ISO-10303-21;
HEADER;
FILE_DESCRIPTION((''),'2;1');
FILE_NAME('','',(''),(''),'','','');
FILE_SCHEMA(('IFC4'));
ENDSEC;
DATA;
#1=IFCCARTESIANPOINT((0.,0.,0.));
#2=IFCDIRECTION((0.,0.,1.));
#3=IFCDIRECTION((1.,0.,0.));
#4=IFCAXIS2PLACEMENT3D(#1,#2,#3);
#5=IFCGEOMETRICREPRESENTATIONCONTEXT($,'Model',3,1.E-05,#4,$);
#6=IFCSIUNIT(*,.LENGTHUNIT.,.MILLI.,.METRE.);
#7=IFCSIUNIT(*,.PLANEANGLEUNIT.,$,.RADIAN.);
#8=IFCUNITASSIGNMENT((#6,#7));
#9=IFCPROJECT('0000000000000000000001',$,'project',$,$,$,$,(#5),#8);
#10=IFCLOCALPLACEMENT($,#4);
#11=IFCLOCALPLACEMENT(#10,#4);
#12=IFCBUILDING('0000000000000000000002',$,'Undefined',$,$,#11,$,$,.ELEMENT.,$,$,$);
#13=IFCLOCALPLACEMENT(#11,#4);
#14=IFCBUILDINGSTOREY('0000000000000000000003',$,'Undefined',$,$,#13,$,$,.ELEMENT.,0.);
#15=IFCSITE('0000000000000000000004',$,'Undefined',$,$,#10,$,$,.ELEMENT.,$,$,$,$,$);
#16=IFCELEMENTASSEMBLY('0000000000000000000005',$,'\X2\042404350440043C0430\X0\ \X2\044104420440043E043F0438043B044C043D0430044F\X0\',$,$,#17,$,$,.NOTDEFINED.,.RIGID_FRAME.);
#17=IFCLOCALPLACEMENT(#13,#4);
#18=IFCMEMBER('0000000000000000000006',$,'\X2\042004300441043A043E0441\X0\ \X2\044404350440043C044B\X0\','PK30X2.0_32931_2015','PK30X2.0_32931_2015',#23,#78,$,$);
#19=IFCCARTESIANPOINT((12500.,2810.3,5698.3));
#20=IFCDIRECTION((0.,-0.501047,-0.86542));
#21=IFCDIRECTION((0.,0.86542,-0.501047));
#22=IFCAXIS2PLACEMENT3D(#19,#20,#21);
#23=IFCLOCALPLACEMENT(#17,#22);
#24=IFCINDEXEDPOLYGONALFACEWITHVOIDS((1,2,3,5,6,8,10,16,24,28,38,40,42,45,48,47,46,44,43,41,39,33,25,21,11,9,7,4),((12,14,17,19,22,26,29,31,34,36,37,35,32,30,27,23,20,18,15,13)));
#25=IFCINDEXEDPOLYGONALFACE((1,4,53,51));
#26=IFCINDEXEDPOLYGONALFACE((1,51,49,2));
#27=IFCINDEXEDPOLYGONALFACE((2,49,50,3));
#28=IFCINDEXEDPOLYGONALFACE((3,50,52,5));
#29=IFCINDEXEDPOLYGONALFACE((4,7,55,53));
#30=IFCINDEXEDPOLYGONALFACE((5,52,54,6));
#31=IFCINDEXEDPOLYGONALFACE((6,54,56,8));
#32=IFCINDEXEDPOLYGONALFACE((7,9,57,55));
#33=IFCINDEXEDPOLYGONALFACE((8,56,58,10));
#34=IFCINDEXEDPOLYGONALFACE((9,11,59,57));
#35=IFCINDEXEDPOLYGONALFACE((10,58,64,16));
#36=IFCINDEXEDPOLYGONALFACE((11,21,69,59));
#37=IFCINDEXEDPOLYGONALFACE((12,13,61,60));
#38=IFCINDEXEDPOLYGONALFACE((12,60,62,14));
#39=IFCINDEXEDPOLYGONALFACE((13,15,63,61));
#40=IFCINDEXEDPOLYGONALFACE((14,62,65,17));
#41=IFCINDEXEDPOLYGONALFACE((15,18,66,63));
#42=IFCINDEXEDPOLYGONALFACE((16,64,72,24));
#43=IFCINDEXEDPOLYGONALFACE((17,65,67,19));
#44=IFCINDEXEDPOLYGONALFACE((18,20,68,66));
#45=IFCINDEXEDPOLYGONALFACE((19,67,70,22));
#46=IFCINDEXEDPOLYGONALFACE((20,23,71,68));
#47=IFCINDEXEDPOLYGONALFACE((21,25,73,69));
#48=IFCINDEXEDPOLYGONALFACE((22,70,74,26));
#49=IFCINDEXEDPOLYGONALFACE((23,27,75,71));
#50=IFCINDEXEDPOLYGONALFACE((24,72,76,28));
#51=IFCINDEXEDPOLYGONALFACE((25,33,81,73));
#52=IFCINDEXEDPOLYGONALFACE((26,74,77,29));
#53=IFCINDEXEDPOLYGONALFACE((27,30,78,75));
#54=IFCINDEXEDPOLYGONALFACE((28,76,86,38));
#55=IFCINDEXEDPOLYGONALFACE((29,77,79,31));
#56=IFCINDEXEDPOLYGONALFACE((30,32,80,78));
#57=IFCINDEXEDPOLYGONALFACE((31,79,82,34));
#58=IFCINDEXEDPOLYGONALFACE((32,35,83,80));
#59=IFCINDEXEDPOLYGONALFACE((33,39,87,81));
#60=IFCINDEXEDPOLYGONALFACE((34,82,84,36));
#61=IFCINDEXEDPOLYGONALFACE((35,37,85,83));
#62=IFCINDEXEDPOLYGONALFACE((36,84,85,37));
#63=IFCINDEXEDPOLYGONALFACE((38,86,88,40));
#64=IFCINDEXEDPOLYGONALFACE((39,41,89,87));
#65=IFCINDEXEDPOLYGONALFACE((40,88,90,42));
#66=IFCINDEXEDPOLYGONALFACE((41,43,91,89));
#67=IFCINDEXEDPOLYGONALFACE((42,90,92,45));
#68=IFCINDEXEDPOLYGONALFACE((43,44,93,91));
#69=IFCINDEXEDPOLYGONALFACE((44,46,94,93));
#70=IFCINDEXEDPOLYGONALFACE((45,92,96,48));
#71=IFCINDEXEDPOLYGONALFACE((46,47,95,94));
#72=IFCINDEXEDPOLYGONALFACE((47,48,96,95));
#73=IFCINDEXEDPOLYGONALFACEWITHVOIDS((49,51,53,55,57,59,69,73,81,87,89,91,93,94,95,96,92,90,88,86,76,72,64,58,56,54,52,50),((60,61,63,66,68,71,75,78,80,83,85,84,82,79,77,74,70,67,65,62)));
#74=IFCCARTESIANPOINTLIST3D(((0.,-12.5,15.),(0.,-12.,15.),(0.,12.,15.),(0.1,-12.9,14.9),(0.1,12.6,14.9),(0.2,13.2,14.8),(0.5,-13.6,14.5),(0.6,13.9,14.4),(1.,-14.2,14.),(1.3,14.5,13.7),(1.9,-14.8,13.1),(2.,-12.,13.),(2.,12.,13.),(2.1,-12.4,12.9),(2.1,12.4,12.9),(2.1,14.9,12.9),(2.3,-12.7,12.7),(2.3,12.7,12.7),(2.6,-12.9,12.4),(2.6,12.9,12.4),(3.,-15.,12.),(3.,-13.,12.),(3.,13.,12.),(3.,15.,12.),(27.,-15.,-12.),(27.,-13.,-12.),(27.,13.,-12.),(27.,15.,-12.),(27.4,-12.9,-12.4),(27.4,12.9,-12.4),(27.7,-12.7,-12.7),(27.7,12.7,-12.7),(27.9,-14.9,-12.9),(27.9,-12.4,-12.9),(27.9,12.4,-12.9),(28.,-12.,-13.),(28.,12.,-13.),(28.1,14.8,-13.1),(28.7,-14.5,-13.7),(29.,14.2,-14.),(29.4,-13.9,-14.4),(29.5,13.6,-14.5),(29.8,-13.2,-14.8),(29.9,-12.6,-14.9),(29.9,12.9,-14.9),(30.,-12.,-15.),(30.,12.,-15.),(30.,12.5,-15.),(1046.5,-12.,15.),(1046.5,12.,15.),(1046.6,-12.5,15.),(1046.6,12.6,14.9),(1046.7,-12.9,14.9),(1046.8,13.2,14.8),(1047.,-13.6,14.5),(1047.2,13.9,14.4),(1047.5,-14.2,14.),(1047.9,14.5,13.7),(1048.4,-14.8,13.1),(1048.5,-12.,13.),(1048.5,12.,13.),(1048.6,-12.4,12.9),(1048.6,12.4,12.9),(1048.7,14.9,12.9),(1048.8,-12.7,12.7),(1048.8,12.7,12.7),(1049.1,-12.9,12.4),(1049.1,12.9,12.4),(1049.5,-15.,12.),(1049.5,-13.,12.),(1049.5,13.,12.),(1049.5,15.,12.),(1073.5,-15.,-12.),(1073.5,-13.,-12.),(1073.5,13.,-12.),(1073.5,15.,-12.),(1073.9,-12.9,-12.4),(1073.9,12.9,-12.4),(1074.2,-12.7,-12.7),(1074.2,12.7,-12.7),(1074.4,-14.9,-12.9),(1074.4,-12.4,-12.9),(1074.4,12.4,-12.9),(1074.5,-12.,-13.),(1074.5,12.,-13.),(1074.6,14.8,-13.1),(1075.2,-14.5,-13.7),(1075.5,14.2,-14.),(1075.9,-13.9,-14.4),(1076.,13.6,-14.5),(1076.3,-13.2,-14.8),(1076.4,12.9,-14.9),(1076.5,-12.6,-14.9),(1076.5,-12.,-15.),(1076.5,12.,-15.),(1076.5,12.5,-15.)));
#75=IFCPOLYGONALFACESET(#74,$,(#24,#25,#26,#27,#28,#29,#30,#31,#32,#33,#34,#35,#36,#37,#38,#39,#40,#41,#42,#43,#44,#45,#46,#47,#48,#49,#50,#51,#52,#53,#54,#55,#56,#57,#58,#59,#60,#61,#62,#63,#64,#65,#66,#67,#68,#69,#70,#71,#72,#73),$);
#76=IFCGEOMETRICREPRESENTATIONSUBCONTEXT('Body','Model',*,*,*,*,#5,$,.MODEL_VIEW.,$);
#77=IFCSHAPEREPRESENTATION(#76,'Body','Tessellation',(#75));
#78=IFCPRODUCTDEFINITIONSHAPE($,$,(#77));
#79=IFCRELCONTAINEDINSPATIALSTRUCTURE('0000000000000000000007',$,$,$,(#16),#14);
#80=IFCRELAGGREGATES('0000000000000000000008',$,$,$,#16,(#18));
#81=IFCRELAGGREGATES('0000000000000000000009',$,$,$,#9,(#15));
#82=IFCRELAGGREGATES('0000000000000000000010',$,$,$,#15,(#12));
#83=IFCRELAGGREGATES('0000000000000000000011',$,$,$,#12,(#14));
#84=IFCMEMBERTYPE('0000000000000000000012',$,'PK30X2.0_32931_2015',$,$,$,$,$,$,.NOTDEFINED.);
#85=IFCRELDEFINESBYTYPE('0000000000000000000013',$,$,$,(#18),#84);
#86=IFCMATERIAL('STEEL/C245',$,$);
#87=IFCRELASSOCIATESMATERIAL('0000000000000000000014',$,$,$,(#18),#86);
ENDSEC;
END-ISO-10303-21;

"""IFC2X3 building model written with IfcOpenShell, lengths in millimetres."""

from ifc_helpers import new_model, si_unit, frame, origin_with_axes, origin_2d_with_axis, place, context, subcontext, project, spatial, hollow_rectangle, extrude, clip, halfspace, material, type_object, element, aggregate, save


model = new_model("IFC2X3")

# Units and contexts
model_context = context("Model", 3, precision=1e-05, world=origin_with_axes())
body_context = subcontext(model_context, "Body", "Model", "MODEL_VIEW")
ifc_project = project(units=[si_unit("LENGTHUNIT", "METRE", prefix="MILLI"), si_unit("PLANEANGLEUNIT", "RADIAN")], contexts=[model_context])

# Site, building, storey
site_placement = place(None, origin_with_axes())
site = spatial("IfcSite", under=ifc_project, at=site_placement, Name="Undefined", CompositionType="ELEMENT")
building_placement = place(site_placement, origin_with_axes())
building = spatial("IfcBuilding", under=site, at=building_placement, Name="Undefined", CompositionType="ELEMENT")
storey_placement = place(building_placement, origin_with_axes())
storey = spatial("IfcBuildingStorey", under=building, at=storey_placement, Name="Undefined", CompositionType="ELEMENT", Elevation=0.0)

# Shared definitions
ifc_material_1 = material(Name="STEEL/C245")

# Element assembly
assembly_1_placement = place(storey_placement, origin_with_axes())
assembly_1 = element("IfcElementAssembly", 1, at=assembly_1_placement, inside=storey, Name="Ферма стропильная", AssemblyPlace="NOTDEFINED", PredefinedType="RIGID_FRAME")

# Member
member_type_1 = type_object("IfcMemberType", Name="PK30X2.0_32931_2015", PredefinedType="NOTDEFINED")
member_1_placement = place(assembly_1_placement, frame((12500.0, 2810.3, 5698.3), z_axis=(0.0, -0.501047, -0.86542), x_axis=(0.0, 0.86542, -0.501047)))
member_1 = element("IfcMember", 2, at=member_1_placement, type_object=member_type_1, material=ifc_material_1, Name="Раскос фермы", Description="PK30X2.0_32931_2015", ObjectType="PK30X2.0_32931_2015", context=body_context, shape_type="Clipping", body=[
    clip(clip(extrude(hollow_rectangle(XDim=30.0, YDim=30.0, WallThickness=2.0, InnerFilletRadius=1.0, OuterFilletRadius=3.0, at=origin_2d_with_axis()), frame((1102.9, 0.0, 0.0), z_axis=(-1.0, 0.0, 0.0), x_axis=(0.0, -1.0, 0.0)), (0.0, 0.0, 1.0), 1129.2), halfspace(frame((1060.0, 0.0, 1.5), z_axis=(-0.707107, 0.0, -0.707107), x_axis=(0.0, -1.0, 0.0)), True)), halfspace(frame((34.5, 0.0, -19.5), z_axis=(-0.707107, 0.0, -0.707107), x_axis=(0.0, -1.0, 0.0)), False)),
])
aggregate(assembly_1, [member_1])

save(model, "model.ifc")
